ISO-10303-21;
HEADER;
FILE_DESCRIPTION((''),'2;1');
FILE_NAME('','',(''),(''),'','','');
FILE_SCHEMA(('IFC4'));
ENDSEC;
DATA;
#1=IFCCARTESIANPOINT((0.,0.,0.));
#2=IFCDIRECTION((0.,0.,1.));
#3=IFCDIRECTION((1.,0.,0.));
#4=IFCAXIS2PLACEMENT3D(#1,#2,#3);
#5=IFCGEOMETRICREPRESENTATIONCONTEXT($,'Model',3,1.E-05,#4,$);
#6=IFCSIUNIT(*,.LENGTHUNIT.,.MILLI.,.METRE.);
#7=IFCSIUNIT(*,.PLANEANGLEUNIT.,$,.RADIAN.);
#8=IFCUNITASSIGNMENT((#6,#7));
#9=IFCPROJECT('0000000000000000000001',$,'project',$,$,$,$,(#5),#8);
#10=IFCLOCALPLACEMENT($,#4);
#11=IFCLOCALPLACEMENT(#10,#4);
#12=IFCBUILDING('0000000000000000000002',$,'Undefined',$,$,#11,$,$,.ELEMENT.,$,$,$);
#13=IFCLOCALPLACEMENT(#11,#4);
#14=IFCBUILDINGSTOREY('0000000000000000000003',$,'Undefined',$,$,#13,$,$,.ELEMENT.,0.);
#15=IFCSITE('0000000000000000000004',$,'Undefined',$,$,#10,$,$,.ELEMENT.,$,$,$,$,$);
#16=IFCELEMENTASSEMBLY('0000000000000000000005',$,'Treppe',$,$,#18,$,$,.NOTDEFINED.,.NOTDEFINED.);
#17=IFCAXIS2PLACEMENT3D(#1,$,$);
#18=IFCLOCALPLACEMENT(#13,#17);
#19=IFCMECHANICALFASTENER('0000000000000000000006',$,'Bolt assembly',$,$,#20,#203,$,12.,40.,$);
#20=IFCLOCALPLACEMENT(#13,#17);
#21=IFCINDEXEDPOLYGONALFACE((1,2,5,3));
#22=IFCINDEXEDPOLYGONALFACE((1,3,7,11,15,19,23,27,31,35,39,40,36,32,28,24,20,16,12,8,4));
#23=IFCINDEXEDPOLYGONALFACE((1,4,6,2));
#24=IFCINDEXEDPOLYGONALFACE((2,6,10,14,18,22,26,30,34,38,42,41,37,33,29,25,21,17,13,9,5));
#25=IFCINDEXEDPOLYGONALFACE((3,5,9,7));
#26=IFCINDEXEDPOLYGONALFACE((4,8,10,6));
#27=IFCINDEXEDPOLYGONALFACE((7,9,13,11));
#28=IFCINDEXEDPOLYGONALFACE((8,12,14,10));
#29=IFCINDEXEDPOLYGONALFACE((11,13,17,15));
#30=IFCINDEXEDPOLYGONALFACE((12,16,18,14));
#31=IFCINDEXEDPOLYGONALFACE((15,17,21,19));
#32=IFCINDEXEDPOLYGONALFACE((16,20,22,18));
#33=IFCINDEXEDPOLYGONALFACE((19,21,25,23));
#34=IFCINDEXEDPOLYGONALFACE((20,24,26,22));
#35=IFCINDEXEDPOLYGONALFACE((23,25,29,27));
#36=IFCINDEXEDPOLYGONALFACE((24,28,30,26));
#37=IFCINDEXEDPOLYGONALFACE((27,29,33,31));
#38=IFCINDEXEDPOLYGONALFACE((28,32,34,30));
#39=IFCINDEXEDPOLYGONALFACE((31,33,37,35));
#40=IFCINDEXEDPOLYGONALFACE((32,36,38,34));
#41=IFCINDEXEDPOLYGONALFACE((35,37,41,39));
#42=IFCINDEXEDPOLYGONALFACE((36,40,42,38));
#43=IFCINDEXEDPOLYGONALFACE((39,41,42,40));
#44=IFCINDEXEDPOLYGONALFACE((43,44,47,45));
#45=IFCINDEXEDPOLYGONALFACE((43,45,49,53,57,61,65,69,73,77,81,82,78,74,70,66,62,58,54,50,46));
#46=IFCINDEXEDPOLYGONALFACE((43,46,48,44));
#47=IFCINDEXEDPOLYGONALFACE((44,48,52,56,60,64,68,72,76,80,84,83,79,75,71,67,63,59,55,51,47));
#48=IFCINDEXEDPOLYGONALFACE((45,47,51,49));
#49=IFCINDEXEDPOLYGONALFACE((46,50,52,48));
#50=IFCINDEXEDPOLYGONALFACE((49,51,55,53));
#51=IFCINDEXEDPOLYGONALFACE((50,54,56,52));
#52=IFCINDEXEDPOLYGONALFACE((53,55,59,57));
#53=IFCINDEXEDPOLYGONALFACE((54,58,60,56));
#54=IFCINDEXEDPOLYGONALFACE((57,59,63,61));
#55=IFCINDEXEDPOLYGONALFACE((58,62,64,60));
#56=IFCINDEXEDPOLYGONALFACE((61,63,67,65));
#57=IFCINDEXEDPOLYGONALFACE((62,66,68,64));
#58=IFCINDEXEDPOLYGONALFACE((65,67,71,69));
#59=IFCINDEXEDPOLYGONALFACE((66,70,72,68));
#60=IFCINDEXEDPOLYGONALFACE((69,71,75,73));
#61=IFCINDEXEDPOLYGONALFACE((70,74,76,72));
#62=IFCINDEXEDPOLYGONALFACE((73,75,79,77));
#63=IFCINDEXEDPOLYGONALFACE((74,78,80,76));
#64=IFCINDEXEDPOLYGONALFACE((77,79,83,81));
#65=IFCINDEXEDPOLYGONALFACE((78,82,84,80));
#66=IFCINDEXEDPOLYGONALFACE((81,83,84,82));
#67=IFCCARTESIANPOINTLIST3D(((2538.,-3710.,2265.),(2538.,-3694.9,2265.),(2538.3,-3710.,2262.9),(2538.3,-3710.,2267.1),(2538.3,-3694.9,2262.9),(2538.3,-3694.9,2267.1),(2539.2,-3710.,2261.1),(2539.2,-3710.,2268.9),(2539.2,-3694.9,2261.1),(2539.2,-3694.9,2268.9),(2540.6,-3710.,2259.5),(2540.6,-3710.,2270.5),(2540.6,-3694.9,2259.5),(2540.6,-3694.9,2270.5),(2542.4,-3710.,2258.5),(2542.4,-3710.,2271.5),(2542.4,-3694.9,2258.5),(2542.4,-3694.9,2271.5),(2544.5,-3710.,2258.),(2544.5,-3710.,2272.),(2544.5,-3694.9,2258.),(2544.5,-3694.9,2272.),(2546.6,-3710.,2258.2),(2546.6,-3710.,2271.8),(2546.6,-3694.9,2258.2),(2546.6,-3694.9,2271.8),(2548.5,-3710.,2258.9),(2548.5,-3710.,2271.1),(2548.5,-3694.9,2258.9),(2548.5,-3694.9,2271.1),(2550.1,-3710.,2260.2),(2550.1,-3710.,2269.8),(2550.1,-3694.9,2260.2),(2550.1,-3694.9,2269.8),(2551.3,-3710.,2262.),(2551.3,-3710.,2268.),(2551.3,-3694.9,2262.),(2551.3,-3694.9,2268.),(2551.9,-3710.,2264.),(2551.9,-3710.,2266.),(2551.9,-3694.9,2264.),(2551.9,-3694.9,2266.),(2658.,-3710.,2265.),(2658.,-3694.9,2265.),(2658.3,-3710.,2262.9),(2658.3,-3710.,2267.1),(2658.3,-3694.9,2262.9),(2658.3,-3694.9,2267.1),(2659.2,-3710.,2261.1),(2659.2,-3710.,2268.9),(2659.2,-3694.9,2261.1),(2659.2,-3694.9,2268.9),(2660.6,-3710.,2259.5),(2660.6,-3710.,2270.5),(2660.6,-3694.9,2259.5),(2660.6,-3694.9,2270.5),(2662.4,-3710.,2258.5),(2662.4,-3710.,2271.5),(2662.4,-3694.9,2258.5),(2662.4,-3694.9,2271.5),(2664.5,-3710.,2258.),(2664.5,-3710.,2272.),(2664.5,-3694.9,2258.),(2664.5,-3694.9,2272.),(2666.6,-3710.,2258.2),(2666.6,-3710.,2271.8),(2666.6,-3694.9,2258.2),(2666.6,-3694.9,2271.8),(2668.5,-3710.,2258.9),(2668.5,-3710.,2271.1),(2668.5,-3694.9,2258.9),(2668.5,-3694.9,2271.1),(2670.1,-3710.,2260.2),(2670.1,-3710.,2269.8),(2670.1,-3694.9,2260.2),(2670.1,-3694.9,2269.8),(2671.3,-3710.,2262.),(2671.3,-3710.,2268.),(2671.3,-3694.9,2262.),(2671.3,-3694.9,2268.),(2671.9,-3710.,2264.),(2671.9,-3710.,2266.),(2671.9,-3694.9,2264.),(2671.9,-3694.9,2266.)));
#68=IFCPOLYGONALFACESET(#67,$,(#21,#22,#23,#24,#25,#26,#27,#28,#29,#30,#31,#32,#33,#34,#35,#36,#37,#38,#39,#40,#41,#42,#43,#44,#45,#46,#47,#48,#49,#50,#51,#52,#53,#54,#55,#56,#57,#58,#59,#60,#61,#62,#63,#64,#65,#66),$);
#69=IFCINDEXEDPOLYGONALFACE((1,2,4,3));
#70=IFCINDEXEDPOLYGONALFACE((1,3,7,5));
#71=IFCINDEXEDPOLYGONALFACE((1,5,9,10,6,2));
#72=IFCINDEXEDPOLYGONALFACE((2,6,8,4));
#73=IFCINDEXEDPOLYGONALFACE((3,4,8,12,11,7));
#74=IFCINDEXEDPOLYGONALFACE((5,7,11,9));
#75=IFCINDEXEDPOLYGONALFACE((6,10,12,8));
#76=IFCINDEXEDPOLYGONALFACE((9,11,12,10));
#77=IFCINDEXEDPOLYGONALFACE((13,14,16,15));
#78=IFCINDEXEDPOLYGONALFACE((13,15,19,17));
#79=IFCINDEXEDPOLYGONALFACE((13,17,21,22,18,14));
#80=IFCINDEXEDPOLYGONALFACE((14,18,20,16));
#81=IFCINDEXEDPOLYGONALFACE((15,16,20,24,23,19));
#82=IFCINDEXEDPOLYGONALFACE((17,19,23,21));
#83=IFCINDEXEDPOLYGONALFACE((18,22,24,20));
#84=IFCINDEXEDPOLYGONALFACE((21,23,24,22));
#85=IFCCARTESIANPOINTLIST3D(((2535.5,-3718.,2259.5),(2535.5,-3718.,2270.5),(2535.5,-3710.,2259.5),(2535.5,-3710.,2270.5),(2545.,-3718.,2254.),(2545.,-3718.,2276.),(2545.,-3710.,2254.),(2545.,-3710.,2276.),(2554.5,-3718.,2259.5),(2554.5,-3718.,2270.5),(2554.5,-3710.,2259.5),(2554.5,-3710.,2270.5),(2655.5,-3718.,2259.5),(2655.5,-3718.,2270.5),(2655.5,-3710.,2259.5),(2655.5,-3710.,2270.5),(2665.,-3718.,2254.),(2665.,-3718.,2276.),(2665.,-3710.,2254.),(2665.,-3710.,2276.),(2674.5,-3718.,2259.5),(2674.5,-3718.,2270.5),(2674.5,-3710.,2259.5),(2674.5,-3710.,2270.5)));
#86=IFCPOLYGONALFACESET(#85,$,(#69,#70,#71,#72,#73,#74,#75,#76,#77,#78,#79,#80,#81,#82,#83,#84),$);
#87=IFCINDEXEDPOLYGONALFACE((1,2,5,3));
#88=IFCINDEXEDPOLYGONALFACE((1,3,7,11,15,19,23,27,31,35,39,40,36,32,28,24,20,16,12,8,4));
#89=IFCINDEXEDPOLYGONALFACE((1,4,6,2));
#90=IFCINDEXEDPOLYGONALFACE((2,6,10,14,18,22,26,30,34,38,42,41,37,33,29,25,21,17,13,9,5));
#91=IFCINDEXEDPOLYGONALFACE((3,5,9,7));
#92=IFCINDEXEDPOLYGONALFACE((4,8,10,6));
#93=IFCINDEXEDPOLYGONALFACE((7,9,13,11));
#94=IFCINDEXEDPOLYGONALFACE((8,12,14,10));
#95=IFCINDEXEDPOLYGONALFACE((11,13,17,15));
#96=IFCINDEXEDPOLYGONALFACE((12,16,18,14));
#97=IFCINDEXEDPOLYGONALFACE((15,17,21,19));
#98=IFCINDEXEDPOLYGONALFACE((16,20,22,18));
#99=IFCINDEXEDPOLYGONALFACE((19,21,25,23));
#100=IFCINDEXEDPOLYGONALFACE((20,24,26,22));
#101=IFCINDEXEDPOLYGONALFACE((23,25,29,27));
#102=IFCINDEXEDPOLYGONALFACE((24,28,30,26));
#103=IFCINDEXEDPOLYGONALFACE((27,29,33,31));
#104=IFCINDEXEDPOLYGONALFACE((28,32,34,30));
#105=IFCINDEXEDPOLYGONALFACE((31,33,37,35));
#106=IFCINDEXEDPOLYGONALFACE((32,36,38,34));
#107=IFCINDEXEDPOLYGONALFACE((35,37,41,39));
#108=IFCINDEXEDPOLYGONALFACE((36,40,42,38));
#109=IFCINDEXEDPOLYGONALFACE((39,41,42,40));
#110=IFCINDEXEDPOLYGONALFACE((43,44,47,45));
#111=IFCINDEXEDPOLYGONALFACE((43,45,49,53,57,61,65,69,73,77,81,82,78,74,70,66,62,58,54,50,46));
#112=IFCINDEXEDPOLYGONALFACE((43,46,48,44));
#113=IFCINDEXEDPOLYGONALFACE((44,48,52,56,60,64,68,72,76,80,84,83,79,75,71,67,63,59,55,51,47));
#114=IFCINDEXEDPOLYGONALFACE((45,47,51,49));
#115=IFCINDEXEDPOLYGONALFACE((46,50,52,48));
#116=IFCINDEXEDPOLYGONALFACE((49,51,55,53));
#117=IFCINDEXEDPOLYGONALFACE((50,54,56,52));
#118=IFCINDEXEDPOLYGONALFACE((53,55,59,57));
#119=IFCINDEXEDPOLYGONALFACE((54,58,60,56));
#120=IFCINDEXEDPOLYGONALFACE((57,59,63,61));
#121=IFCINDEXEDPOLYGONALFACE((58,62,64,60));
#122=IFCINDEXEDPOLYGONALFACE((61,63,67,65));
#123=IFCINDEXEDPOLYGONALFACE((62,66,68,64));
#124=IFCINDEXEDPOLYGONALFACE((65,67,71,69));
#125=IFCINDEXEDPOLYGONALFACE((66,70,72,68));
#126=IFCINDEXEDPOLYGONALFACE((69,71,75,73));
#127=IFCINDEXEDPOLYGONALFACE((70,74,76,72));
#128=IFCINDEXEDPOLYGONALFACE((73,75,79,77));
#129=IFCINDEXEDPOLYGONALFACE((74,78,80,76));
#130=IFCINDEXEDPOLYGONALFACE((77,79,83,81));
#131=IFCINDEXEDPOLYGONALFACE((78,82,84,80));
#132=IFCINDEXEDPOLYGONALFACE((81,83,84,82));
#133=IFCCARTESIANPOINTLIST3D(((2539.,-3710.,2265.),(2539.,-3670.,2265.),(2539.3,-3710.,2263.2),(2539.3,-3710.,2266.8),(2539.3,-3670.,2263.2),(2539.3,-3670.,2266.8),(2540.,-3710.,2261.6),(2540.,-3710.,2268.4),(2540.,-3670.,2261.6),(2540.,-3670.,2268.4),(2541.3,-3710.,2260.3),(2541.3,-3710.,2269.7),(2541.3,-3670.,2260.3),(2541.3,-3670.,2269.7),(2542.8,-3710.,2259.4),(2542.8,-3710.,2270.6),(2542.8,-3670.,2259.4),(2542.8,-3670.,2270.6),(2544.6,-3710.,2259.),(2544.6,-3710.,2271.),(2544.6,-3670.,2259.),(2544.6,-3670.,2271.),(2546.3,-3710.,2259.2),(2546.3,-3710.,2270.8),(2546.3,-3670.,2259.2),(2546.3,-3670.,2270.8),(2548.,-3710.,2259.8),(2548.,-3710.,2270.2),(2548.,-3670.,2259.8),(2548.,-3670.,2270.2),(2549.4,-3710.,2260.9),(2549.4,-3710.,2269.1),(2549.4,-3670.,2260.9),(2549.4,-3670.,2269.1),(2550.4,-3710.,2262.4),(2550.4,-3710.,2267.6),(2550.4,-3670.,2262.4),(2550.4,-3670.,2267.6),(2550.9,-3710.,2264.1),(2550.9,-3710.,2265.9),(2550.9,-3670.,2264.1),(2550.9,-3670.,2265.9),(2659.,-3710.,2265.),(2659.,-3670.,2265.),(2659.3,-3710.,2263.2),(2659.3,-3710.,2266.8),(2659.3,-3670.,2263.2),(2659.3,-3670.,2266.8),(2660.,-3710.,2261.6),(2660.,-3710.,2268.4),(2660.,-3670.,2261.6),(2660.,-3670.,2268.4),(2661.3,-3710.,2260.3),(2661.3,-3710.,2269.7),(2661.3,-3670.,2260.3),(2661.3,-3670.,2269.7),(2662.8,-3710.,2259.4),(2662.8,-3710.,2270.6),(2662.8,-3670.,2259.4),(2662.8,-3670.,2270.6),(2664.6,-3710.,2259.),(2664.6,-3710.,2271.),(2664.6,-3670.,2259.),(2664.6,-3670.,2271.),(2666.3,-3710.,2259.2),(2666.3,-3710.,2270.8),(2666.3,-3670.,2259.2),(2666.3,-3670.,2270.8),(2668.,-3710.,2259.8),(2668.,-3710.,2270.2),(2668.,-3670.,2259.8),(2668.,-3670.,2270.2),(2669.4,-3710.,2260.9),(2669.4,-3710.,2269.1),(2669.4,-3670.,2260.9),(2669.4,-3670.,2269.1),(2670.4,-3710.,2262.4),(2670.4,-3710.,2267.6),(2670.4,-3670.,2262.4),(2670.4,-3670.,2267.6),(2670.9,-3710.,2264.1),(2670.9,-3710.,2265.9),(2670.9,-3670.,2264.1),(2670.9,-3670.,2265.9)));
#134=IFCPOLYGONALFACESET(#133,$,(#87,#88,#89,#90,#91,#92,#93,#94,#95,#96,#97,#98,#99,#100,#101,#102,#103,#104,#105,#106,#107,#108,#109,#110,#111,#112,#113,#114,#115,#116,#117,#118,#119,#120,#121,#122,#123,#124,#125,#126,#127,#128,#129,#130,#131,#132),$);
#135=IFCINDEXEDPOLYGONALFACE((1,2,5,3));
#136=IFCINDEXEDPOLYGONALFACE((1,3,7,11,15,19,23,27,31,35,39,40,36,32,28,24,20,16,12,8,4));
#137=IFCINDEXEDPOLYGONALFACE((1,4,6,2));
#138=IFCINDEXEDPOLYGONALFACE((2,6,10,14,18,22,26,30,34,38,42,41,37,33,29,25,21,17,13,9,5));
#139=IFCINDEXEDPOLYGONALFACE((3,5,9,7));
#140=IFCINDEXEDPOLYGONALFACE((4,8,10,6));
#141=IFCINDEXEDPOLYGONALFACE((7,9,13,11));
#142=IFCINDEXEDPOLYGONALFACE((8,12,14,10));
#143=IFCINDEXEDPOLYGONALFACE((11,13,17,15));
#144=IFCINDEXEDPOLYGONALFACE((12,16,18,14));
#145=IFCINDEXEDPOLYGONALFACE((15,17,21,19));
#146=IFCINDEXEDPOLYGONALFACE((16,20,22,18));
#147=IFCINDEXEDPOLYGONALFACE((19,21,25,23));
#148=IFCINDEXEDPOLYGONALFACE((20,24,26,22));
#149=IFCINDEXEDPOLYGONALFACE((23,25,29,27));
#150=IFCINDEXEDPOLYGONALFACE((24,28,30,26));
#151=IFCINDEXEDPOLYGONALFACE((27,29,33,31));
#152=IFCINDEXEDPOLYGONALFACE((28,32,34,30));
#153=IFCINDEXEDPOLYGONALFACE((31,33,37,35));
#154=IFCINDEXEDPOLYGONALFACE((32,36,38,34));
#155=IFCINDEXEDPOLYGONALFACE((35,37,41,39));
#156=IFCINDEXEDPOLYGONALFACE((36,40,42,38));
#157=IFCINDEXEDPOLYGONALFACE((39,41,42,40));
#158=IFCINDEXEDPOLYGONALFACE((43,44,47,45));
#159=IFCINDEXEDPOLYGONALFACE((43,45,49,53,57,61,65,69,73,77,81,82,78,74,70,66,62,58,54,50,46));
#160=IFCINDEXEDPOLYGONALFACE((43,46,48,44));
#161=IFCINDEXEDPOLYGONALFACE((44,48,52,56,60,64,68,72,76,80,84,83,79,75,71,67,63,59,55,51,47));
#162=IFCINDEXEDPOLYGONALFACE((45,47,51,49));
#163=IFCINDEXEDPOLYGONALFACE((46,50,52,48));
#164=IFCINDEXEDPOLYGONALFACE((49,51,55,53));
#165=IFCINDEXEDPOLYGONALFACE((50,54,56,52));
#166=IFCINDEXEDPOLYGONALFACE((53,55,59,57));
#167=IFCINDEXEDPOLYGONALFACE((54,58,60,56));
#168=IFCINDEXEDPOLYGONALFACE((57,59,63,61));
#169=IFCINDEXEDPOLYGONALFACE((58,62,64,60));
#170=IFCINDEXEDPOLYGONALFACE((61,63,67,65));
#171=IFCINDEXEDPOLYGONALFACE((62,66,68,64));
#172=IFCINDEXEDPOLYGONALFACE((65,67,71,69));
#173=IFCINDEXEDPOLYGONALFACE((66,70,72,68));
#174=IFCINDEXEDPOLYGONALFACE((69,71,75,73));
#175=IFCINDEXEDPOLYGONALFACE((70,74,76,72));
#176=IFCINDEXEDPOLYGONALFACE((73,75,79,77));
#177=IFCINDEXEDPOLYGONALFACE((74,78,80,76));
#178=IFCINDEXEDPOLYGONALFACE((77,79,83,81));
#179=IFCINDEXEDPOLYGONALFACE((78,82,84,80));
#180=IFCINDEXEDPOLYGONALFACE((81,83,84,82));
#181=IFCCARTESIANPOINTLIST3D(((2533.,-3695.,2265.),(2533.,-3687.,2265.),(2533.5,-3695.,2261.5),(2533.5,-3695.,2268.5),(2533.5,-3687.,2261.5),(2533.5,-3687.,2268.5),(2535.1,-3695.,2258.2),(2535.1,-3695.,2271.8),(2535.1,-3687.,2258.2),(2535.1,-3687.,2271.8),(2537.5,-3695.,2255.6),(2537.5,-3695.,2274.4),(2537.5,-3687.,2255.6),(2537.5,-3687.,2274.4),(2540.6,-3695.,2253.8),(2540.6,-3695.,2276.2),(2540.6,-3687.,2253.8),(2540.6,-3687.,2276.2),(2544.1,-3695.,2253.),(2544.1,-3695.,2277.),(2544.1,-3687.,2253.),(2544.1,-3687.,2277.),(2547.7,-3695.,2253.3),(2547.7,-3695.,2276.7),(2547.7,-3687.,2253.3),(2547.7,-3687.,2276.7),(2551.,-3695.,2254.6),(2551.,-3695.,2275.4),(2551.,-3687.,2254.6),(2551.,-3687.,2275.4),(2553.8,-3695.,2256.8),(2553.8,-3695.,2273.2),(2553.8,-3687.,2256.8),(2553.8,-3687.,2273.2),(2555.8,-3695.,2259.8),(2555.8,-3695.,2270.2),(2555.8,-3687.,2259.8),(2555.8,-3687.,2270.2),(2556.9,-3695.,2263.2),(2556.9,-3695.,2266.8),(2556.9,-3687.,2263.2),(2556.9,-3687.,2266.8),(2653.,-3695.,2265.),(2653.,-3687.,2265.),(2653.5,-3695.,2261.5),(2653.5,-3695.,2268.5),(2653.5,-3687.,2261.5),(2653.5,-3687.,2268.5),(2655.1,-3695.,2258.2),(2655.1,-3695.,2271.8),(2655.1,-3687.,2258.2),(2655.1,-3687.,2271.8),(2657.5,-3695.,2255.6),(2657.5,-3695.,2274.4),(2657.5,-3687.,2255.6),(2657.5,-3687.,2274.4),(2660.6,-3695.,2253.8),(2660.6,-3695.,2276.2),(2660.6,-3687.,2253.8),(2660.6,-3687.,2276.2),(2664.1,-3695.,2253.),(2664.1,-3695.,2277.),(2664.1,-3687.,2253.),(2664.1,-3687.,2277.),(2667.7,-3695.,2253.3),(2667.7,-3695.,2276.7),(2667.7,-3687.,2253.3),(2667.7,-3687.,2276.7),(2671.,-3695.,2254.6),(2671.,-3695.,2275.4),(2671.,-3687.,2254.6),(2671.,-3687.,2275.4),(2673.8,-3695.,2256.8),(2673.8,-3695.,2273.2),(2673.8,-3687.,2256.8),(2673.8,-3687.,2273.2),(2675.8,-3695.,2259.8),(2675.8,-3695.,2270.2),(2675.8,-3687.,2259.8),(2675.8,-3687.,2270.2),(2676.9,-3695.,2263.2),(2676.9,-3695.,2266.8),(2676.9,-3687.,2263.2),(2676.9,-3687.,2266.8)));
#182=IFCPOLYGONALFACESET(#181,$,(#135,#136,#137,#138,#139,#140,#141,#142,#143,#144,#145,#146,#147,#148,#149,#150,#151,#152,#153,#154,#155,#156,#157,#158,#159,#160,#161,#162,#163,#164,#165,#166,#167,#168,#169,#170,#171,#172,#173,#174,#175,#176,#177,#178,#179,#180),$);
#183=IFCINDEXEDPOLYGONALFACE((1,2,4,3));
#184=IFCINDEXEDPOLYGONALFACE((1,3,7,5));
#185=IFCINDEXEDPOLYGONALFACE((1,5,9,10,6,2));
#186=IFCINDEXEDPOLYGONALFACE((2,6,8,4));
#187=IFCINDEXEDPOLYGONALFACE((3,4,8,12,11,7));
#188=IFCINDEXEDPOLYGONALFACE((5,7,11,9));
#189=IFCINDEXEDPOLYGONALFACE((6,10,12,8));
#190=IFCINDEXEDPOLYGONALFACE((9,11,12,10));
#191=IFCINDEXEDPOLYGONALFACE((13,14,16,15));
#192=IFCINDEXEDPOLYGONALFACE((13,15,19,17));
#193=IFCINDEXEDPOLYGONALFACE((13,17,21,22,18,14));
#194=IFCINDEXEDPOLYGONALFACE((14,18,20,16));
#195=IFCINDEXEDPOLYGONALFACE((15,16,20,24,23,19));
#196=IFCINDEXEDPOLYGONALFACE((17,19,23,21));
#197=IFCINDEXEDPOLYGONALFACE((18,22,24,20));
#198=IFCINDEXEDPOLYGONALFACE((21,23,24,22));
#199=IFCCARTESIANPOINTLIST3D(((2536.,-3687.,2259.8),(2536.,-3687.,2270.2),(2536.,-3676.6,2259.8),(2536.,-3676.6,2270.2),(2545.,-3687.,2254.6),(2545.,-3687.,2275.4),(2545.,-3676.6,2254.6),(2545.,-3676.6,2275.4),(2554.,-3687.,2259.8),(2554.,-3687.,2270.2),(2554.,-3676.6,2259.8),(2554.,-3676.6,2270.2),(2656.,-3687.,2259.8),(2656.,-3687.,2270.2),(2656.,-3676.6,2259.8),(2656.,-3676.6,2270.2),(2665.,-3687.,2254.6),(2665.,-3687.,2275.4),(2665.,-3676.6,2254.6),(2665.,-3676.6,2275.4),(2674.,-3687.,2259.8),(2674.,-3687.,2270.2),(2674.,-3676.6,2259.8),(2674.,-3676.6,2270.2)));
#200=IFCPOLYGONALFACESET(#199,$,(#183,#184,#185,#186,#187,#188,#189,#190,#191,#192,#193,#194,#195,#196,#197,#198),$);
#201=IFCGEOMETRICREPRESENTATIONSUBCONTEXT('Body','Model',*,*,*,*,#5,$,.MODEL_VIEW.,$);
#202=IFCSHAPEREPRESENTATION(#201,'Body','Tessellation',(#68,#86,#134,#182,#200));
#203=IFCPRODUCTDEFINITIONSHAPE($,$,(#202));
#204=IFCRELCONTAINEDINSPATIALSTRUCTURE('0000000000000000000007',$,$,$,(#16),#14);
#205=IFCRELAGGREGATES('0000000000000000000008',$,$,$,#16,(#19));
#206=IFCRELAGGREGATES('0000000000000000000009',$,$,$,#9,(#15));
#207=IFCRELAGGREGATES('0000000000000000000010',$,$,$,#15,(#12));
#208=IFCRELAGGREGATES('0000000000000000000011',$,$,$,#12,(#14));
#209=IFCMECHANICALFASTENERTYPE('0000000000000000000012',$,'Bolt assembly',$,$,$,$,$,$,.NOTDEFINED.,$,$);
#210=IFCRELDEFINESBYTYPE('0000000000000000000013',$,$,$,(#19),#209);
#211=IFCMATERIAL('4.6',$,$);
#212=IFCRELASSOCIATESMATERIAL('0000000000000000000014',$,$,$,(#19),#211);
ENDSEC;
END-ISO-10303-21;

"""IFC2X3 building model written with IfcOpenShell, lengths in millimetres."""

from ifc_helpers import new_model, si_unit, frame, origin_with_axes, origin_2d_with_axis, place, context, subcontext, project, spatial, polyline, circle, outline, extrude, source, transform, mapped, material, type_object, element, aggregate, save


model = new_model("IFC2X3")

# Units and contexts
model_context = context("Model", 3, precision=1e-05, world=origin_with_axes())
body_context = subcontext(model_context, "Body", "Model", "MODEL_VIEW")
ifc_project = project(units=[si_unit("LENGTHUNIT", "METRE", prefix="MILLI"), si_unit("PLANEANGLEUNIT", "RADIAN")], contexts=[model_context])

# Site, building, storey
site_placement = place(None, origin_with_axes())
site = spatial("IfcSite", under=ifc_project, at=site_placement, Name="Undefined", CompositionType="ELEMENT")
building_placement = place(site_placement, origin_with_axes())
building = spatial("IfcBuilding", under=site, at=building_placement, Name="Undefined", CompositionType="ELEMENT")
storey_placement = place(building_placement, origin_with_axes())
storey = spatial("IfcBuildingStorey", under=building, at=storey_placement, Name="Undefined", CompositionType="ELEMENT", Elevation=0.0)

# Shared definitions
mechanical_fastener_type = type_object("IfcMechanicalFastenerType", Name="Bolt assembly")

# Element assembly, mechanical fastener
assembly_1_placement = place(storey_placement, origin_with_axes())
assembly_1 = element("IfcElementAssembly", 1, at=assembly_1_placement, inside=storey, Name="Treppe", AssemblyPlace="NOTDEFINED", PredefinedType="NOTDEFINED")
ifc_material_1 = material(Name="4.6")
shared_shape_1 = source(origin_with_axes(), body_context, "Body", "SweptSolid", [
    extrude(circle(Radius=7.0, at=origin_2d_with_axis()), frame((0.0, 0.0, 0.0), z_axis=(0.0, 1.0, 0.0), x_axis=(1.0, 0.0, 0.0)), (0.0, 0.0, 1.0), 15.1),
    extrude(outline(polyline([(9.5, -5.5), (9.5, 5.5), (0.0, 11.0), (-9.5, 5.5), (-9.5, -5.5), (0.0, -11.0), (9.5, -5.5)])), frame((0.0, -8.0, 0.0), z_axis=(0.0, 1.0, 0.0), x_axis=(1.0, 0.0, 0.0)), (0.0, 0.0, 1.0), 8.0),
    extrude(circle(Radius=6.0, at=origin_2d_with_axis()), frame((0.0, 0.0, 0.0), z_axis=(0.0, 1.0, 0.0), x_axis=(1.0, 0.0, 0.0)), (0.0, 0.0, 1.0), 40.0),
    extrude(circle(Radius=12.0, at=origin_2d_with_axis()), frame((0.0, 15.0, 0.0), z_axis=(0.0, 1.0, 0.0), x_axis=(1.0, 0.0, 0.0)), (0.0, 0.0, 1.0), 8.0),
    extrude(outline(polyline([(9.0, -5.2), (9.0, 5.2), (0.0, 10.4), (-9.0, 5.2), (-9.0, -5.2), (0.0, -10.4), (9.0, -5.2)])), frame((0.0, 23.0, 0.0), z_axis=(0.0, 1.0, 0.0), x_axis=(1.0, 0.0, 0.0)), (0.0, 0.0, 1.0), 10.4),
])
mechanical_fastener_1_placement = place(assembly_1_placement, frame((2665.0, -3710.0, 2265.0), z_axis=(0.0, 0.0, -1.0), x_axis=(-1.0, 0.0, 0.0)))
mechanical_fastener_1 = element("IfcMechanicalFastener", 2, at=mechanical_fastener_1_placement, type_object=mechanical_fastener_type, material=ifc_material_1, Name="Bolt assembly", NominalDiameter=12.0, NominalLength=40.0, context=body_context, shape_type="MappedRepresentation", body=[
    mapped(shared_shape_1, transform((0.0, 0.0, 0.0))),
    mapped(shared_shape_1, transform((120.0, 0.0, 0.0))),
])
aggregate(assembly_1, [mechanical_fastener_1])

save(model, "model.ifc")
